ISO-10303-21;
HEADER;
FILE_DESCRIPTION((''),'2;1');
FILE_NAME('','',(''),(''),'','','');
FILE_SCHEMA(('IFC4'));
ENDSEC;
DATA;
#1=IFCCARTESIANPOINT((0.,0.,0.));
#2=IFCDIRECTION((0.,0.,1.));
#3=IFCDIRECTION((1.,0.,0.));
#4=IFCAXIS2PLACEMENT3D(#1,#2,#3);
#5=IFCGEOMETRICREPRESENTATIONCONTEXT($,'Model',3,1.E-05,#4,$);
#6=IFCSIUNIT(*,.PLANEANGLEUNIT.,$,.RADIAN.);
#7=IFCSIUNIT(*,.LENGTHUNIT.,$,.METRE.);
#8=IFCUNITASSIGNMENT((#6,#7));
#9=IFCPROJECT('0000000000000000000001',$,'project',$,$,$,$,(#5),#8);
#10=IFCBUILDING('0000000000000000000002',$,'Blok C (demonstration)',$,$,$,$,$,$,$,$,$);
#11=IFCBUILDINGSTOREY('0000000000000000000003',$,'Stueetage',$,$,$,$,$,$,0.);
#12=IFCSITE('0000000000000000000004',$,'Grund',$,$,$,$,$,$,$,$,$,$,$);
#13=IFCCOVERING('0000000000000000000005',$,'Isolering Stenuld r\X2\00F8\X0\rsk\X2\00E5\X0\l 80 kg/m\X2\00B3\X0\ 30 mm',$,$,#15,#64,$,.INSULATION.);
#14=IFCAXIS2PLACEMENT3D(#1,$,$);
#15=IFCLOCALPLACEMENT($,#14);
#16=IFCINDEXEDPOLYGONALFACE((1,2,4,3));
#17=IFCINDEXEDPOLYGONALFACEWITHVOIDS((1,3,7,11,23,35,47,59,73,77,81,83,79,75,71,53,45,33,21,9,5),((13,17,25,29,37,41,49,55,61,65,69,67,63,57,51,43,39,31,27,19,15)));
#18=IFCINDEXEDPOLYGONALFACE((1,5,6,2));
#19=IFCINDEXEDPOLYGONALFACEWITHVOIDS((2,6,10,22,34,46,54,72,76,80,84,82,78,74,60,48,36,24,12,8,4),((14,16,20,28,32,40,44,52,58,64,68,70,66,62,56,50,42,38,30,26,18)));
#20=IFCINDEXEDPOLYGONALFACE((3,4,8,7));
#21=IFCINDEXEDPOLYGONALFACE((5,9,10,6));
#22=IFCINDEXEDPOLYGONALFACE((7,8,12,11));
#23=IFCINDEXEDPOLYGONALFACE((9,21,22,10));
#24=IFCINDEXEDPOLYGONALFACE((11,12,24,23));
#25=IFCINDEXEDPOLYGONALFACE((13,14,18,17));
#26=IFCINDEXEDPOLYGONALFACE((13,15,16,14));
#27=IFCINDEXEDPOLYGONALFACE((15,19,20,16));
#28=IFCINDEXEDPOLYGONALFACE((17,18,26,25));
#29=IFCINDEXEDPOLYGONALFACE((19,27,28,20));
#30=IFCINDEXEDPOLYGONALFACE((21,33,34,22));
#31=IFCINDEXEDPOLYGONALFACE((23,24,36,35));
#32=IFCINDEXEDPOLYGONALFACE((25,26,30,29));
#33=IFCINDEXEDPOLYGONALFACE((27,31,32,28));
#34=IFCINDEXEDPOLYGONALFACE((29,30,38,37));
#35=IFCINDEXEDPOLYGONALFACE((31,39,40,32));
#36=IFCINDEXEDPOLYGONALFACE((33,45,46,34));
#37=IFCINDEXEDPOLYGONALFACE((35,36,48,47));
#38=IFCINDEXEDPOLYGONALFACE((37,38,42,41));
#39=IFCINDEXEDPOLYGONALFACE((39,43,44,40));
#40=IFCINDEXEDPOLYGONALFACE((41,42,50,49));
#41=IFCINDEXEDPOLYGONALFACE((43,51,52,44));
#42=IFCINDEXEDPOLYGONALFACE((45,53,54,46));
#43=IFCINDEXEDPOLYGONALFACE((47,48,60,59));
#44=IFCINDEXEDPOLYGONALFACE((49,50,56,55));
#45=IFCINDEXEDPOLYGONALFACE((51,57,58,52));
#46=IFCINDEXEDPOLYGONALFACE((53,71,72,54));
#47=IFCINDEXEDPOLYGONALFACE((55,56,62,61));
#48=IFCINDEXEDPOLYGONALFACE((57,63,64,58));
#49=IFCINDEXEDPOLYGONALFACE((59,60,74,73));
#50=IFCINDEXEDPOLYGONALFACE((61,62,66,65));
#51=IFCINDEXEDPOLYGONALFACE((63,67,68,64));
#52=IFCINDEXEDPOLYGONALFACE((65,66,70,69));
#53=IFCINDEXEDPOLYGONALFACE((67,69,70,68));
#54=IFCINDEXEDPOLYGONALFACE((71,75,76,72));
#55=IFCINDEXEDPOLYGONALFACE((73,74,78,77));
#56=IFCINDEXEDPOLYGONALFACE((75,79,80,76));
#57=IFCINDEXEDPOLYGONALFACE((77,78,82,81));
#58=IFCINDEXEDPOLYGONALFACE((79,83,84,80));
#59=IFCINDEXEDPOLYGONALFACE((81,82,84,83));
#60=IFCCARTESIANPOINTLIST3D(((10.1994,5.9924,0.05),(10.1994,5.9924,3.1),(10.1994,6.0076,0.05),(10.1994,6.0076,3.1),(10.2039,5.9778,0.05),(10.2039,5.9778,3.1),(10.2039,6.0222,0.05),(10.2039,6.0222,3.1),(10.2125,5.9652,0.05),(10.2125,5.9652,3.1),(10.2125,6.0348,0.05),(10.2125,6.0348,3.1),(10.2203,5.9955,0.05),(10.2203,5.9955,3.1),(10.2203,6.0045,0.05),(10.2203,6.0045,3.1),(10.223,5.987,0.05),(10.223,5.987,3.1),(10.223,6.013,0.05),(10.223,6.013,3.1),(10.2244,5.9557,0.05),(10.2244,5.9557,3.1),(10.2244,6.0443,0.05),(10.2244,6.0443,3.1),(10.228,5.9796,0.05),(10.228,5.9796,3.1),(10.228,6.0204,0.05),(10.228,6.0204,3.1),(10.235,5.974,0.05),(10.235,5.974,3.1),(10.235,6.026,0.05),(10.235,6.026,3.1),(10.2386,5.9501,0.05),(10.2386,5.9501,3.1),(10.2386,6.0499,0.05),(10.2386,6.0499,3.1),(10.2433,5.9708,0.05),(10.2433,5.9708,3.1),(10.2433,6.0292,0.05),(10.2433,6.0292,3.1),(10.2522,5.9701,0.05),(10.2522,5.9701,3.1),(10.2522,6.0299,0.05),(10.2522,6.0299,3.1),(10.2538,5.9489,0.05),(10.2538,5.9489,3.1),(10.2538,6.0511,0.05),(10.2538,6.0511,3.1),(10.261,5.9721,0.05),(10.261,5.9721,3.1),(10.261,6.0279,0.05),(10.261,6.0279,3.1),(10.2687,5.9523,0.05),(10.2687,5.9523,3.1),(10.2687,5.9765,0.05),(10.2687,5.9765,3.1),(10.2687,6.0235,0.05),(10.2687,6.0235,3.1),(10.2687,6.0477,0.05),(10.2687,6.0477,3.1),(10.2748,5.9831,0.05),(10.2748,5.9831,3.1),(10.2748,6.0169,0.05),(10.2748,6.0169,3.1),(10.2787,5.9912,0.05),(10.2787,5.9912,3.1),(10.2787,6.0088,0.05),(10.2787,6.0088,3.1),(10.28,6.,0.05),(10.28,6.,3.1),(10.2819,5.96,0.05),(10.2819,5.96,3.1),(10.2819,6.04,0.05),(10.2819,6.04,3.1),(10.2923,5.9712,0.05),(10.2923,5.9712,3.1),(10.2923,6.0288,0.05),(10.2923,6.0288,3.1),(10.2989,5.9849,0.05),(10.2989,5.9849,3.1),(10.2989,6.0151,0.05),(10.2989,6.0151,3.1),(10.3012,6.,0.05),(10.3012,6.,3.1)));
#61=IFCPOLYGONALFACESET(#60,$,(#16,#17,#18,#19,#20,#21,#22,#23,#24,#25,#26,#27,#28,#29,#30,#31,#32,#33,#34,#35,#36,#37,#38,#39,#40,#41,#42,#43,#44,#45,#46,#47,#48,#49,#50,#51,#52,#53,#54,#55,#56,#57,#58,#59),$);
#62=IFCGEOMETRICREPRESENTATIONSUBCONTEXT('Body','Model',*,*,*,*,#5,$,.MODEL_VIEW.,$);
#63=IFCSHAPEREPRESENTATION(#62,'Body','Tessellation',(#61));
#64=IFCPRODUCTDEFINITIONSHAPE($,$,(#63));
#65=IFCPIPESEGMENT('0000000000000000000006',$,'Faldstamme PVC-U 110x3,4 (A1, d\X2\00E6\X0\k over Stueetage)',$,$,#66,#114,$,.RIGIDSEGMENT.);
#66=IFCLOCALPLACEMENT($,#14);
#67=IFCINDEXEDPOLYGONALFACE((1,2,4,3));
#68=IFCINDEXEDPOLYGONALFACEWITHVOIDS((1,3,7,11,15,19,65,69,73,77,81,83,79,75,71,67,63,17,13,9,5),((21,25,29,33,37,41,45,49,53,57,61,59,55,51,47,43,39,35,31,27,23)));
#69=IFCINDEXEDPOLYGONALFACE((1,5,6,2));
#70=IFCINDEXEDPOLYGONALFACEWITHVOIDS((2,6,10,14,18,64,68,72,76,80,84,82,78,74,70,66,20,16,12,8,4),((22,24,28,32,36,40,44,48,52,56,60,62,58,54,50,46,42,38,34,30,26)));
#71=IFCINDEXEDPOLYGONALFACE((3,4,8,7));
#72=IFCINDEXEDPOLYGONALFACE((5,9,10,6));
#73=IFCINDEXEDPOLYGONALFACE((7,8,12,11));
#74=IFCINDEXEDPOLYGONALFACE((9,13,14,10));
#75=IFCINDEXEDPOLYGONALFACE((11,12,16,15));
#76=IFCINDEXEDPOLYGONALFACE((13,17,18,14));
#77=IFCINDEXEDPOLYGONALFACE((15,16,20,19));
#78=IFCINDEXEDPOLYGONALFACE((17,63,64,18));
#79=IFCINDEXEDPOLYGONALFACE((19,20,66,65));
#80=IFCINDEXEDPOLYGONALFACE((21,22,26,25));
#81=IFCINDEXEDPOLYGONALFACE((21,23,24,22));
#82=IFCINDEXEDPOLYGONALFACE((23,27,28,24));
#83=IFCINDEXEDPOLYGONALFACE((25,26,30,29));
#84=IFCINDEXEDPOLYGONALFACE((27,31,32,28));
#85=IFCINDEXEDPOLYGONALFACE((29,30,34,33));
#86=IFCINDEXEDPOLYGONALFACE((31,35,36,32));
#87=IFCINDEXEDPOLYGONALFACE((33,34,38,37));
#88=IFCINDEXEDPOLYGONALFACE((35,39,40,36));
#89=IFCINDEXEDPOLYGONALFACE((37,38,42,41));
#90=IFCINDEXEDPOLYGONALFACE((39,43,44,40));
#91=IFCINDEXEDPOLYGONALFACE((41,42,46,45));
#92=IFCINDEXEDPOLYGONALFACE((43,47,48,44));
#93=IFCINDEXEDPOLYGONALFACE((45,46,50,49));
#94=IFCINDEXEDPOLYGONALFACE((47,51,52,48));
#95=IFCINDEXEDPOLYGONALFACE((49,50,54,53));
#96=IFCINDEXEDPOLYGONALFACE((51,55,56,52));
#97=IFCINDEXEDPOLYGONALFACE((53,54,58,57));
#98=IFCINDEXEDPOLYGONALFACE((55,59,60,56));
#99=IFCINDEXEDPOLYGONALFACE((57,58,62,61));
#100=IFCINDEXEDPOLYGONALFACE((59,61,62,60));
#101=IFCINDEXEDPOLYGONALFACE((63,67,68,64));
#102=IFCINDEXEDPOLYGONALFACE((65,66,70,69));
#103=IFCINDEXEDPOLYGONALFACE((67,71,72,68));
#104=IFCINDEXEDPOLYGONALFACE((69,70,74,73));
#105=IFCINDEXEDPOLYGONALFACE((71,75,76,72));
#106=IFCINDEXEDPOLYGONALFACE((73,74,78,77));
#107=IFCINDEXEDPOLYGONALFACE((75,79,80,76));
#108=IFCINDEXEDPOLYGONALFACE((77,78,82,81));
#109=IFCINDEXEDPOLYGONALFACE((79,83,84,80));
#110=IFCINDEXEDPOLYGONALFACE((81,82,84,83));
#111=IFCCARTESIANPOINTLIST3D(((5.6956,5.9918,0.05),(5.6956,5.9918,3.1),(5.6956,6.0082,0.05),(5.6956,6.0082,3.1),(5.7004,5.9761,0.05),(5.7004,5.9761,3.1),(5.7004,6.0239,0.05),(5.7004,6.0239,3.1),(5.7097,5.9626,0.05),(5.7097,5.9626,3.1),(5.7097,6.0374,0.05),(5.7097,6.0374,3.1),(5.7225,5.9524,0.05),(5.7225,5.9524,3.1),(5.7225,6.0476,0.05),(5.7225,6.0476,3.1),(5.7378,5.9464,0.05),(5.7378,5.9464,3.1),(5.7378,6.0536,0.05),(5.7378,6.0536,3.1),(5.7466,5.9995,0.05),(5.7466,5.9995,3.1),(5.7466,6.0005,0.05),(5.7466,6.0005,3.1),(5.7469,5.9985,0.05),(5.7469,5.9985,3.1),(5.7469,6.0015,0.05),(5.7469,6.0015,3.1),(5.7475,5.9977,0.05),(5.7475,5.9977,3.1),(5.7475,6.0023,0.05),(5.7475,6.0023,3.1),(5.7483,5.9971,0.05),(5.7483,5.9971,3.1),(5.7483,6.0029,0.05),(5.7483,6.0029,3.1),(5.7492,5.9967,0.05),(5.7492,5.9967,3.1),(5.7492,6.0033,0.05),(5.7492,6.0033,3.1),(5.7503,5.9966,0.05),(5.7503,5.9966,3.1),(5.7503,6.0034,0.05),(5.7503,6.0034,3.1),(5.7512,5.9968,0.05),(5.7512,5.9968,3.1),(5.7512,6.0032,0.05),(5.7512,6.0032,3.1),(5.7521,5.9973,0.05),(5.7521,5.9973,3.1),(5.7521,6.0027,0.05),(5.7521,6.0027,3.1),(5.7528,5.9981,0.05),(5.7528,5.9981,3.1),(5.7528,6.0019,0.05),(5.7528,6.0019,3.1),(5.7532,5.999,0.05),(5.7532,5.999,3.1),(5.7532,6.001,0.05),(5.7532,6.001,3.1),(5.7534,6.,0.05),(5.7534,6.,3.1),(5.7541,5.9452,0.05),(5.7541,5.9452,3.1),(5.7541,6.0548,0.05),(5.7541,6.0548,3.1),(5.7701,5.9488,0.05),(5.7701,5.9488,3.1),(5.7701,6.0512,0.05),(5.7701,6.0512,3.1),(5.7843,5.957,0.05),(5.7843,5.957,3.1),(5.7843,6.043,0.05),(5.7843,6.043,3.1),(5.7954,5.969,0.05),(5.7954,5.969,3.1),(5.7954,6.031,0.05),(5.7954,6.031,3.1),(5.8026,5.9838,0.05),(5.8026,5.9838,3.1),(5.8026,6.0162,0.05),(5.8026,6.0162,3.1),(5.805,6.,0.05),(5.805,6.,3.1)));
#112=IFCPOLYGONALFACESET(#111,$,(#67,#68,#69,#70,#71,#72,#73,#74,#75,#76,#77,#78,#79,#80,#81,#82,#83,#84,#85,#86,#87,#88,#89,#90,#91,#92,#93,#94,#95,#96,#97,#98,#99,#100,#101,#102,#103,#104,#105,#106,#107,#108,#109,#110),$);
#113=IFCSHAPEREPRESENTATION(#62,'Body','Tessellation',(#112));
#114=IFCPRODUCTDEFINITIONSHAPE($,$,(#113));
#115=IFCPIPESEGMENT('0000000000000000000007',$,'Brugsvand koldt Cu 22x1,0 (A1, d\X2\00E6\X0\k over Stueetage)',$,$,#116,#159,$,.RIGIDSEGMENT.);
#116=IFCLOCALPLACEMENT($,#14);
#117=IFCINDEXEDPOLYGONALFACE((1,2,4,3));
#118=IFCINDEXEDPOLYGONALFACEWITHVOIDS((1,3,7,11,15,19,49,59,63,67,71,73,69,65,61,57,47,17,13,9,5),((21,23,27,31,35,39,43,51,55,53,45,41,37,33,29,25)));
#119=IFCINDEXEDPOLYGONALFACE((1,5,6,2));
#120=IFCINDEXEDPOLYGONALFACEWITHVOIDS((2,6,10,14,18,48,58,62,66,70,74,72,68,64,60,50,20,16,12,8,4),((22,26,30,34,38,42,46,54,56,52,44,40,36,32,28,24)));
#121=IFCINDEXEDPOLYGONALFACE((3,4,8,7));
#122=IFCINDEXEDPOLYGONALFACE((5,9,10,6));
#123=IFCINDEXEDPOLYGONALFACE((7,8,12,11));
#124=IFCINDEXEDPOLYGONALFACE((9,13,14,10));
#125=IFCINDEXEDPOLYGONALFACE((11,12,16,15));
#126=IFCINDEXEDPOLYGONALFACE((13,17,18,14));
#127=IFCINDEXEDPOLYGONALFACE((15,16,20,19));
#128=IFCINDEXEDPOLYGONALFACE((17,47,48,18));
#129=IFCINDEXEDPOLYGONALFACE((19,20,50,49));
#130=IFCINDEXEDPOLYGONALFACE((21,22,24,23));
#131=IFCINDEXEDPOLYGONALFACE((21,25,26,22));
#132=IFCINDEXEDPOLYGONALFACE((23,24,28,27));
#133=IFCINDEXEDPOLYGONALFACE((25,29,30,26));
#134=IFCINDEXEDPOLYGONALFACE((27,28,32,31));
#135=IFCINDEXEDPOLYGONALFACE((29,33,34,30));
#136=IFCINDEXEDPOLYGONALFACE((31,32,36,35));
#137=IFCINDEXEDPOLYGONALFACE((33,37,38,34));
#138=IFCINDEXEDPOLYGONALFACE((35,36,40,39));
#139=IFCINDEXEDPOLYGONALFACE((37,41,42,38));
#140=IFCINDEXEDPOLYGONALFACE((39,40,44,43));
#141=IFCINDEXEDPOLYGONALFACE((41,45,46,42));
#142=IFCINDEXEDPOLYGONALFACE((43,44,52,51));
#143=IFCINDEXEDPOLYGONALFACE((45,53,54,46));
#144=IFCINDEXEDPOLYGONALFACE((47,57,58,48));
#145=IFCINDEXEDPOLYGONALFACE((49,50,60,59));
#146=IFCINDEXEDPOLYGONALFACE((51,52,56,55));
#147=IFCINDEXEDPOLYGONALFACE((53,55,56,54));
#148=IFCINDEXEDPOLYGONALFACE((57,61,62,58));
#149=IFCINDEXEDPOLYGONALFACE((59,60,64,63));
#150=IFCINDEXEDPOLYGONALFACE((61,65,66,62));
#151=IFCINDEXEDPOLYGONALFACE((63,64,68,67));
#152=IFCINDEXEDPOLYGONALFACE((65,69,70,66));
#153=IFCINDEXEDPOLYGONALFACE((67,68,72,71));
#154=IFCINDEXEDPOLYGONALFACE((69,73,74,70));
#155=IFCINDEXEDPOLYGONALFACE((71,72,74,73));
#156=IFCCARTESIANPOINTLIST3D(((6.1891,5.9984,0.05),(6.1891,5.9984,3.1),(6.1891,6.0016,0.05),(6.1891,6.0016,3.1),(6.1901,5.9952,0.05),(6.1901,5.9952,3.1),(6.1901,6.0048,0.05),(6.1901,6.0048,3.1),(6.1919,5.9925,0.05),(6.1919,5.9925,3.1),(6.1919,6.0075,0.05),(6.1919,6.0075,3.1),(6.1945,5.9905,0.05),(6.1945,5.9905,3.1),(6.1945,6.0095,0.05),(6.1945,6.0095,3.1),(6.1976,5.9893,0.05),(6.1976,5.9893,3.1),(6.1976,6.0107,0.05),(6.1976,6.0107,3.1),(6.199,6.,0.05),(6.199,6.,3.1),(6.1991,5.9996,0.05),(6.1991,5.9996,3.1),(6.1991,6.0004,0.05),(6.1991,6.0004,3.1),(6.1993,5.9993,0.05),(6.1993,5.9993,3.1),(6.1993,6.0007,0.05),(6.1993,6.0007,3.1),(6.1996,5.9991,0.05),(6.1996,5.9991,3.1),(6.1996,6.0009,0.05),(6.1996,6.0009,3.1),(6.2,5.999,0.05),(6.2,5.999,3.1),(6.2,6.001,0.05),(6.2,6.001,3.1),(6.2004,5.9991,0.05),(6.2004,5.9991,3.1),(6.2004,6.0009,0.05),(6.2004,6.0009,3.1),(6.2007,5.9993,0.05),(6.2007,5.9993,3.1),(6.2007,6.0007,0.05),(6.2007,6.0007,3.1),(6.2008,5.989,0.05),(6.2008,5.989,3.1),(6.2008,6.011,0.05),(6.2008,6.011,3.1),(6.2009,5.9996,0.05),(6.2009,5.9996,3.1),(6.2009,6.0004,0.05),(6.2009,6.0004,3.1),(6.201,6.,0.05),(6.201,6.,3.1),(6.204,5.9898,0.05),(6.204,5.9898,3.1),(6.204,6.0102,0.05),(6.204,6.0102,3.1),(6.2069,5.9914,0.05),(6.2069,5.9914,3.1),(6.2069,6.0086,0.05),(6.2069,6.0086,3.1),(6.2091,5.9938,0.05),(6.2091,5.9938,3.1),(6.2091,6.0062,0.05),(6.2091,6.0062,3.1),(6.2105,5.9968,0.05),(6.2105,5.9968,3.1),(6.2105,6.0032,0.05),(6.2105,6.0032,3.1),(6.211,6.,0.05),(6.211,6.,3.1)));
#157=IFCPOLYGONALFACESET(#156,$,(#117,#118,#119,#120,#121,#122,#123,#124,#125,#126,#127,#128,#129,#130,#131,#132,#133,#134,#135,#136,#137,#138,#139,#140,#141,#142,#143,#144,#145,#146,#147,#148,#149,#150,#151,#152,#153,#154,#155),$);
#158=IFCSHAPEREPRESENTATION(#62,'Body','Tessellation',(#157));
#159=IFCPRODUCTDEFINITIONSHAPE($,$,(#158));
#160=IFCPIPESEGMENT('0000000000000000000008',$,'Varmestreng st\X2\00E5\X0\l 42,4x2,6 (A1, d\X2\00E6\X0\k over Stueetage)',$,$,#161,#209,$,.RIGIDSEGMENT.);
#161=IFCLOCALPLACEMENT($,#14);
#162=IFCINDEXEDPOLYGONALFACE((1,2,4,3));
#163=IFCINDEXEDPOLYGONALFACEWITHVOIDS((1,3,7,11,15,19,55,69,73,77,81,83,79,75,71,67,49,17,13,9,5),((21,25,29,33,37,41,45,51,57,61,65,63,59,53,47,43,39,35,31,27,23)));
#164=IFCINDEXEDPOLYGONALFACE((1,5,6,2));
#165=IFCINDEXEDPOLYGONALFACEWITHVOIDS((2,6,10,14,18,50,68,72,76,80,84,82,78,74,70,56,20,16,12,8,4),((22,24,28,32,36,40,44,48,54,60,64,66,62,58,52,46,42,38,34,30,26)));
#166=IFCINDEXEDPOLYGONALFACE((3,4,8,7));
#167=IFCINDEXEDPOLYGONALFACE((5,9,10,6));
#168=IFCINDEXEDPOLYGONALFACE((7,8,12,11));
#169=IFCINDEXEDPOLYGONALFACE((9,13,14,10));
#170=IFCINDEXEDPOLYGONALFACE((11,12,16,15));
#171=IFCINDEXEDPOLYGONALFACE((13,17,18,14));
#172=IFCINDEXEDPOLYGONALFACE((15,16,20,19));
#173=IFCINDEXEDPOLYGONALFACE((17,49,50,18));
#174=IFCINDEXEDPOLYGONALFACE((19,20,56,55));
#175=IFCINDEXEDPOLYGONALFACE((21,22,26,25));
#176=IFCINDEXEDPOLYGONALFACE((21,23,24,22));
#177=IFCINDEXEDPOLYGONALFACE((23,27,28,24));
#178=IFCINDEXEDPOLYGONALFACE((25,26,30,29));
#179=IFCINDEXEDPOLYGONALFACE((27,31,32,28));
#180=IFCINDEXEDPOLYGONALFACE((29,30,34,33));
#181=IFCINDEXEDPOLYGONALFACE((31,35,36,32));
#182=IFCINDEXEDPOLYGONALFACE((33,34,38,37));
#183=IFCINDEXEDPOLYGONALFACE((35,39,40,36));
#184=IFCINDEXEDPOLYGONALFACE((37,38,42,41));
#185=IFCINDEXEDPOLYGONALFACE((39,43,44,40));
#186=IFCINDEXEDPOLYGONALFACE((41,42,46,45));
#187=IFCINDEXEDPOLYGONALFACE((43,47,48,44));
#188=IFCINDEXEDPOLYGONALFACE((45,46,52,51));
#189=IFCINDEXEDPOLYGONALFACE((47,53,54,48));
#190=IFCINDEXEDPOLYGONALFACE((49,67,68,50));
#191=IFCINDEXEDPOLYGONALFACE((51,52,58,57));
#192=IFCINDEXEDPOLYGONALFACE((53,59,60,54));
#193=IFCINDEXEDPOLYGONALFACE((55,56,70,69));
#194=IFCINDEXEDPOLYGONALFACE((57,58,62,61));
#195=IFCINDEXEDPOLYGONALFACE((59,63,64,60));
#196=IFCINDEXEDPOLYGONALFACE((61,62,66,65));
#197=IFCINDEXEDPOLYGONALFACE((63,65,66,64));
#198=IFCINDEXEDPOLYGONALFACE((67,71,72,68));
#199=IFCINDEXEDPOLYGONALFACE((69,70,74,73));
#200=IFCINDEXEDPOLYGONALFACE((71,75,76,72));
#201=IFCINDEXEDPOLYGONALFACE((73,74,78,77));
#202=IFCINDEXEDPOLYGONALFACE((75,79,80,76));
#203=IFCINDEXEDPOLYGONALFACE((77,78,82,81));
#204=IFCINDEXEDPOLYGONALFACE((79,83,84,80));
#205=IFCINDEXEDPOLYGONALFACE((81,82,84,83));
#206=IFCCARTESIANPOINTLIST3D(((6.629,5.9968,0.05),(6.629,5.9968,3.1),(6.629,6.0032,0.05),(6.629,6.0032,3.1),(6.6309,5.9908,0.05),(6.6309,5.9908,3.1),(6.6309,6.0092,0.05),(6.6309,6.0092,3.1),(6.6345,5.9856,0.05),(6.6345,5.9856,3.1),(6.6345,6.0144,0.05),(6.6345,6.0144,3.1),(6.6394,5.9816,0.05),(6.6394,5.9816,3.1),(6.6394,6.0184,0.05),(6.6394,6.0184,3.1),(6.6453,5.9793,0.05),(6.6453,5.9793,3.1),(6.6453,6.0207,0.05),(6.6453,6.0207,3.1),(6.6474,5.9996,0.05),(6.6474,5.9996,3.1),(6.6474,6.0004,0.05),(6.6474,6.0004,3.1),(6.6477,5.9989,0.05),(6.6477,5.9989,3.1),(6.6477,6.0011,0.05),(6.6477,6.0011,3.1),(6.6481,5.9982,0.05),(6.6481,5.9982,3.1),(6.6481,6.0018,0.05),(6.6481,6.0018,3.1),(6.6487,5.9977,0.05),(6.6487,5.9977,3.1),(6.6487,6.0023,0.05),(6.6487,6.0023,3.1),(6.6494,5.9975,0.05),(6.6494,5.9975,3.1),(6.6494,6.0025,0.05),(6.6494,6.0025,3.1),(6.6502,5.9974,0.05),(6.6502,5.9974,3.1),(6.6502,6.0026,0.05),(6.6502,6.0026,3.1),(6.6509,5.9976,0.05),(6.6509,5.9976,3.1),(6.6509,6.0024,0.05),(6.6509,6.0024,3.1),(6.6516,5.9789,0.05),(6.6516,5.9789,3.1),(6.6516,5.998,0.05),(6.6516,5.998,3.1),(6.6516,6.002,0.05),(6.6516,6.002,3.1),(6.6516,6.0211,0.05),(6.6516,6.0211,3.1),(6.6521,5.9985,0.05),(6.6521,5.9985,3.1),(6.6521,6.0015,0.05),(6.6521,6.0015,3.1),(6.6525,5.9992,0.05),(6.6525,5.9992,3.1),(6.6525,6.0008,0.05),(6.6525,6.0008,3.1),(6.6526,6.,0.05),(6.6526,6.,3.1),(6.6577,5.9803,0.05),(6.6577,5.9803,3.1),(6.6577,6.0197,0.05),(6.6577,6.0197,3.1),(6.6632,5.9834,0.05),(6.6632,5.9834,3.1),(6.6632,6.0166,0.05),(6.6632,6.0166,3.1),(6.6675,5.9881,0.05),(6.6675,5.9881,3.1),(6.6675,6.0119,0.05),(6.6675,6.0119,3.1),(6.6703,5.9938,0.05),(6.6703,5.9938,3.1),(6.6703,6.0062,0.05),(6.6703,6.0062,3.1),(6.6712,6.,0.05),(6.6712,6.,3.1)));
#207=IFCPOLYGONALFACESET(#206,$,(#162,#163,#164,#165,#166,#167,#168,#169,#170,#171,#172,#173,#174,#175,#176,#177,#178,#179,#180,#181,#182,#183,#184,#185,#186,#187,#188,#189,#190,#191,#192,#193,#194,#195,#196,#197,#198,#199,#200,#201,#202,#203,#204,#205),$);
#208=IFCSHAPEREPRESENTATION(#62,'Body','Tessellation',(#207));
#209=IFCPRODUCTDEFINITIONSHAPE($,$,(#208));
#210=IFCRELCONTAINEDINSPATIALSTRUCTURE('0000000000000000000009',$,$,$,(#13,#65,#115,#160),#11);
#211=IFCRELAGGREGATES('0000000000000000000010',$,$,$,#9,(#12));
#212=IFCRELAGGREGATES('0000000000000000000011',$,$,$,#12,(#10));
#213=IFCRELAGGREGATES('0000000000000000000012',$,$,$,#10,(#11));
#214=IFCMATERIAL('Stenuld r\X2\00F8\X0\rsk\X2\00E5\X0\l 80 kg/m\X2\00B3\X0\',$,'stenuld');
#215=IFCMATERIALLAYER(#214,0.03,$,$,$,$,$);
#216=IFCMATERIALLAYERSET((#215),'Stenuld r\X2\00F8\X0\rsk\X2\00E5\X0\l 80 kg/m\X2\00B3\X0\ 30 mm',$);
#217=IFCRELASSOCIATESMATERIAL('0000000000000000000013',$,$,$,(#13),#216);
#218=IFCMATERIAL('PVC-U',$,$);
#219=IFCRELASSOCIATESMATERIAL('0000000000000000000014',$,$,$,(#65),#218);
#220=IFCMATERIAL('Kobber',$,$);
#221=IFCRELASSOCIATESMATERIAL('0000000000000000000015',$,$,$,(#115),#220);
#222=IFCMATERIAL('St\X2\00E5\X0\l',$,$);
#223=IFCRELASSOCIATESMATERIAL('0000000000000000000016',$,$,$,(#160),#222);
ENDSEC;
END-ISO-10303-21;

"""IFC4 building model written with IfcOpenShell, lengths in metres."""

from ifc_helpers import new_model, si_unit, frame, origin_with_axes, place, context, subcontext, project, spatial, hollow_circle, extrude, material, layer, layer_set, element, save


model = new_model("IFC4")

# Units and contexts
model_context = context("Model", 3, precision=1e-05, world=origin_with_axes())
body_context = subcontext(model_context, "Body", "Model", "MODEL_VIEW")
ifc_project = project(units=[si_unit("PLANEANGLEUNIT", "RADIAN"), si_unit("LENGTHUNIT", "METRE")], contexts=[model_context])

# Site, building, storey
site = spatial("IfcSite", under=ifc_project, Name="Grund")
building = spatial("IfcBuilding", under=site, Name="Blok C (demonstration)")
storey = spatial("IfcBuildingStorey", under=building, Name="Stueetage", Elevation=0.0)

# Covering
ifc_material_1 = material(Name="Stenuld rørskål 80 kg/m³", Category="stenuld")
ifc_layer_1 = layer(ifc_material_1, 0.03)
ifc_layer_set_1 = layer_set([ifc_layer_1], Name="Stenuld rørskål 80 kg/m³ 30 mm")
covering_1_placement = place(None, origin_with_axes())
element("IfcCovering", 1, at=covering_1_placement, inside=storey, material=ifc_layer_set_1, Name="Isolering Stenuld rørskål 80 kg/m³ 30 mm", PredefinedType="INSULATION", context=body_context, shape_type="SweptSolid", body=[
    extrude(hollow_circle(Radius=0.0512, WallThickness=0.0212), frame((10.25, 6.0, 0.05), z_axis=(0.0, 0.0, 1.0), x_axis=(1.0, 0.0, 0.0)), (0.0, 0.0, 1.0), 3.05),
])

# Pipe segments
ifc_material_2 = material(Name="PVC-U")
pipe_segment_1_placement = place(None, origin_with_axes())
element("IfcPipeSegment", 2, at=pipe_segment_1_placement, inside=storey, material=ifc_material_2, Name="Faldstamme PVC-U 110x3,4 (A1, dæk over Stueetage)", PredefinedType="RIGIDSEGMENT", context=body_context, shape_type="SweptSolid", body=[
    extrude(hollow_circle(Radius=0.055, WallThickness=0.0516), frame((5.75, 6.0, 0.05), z_axis=(0.0, 0.0, 1.0), x_axis=(1.0, 0.0, 0.0)), (0.0, 0.0, 1.0), 3.05),
])
ifc_material_3 = material(Name="Kobber")
pipe_segment_2_placement = place(None, origin_with_axes())
element("IfcPipeSegment", 3, at=pipe_segment_2_placement, inside=storey, material=ifc_material_3, Name="Brugsvand koldt Cu 22x1,0 (A1, dæk over Stueetage)", PredefinedType="RIGIDSEGMENT", context=body_context, shape_type="SweptSolid", body=[
    extrude(hollow_circle(Radius=0.011, WallThickness=0.01), frame((6.2, 6.0, 0.05), z_axis=(0.0, 0.0, 1.0), x_axis=(1.0, 0.0, 0.0)), (0.0, 0.0, 1.0), 3.05),
])
ifc_material_4 = material(Name="Stål")
pipe_segment_3_placement = place(None, origin_with_axes())
element("IfcPipeSegment", 4, at=pipe_segment_3_placement, inside=storey, material=ifc_material_4, Name="Varmestreng stål 42,4x2,6 (A1, dæk over Stueetage)", PredefinedType="RIGIDSEGMENT", context=body_context, shape_type="SweptSolid", body=[
    extrude(hollow_circle(Radius=0.0212, WallThickness=0.0186), frame((6.65, 6.0, 0.05), z_axis=(0.0, 0.0, 1.0), x_axis=(1.0, 0.0, 0.0)), (0.0, 0.0, 1.0), 3.05),
])

save(model, "model.ifc")
